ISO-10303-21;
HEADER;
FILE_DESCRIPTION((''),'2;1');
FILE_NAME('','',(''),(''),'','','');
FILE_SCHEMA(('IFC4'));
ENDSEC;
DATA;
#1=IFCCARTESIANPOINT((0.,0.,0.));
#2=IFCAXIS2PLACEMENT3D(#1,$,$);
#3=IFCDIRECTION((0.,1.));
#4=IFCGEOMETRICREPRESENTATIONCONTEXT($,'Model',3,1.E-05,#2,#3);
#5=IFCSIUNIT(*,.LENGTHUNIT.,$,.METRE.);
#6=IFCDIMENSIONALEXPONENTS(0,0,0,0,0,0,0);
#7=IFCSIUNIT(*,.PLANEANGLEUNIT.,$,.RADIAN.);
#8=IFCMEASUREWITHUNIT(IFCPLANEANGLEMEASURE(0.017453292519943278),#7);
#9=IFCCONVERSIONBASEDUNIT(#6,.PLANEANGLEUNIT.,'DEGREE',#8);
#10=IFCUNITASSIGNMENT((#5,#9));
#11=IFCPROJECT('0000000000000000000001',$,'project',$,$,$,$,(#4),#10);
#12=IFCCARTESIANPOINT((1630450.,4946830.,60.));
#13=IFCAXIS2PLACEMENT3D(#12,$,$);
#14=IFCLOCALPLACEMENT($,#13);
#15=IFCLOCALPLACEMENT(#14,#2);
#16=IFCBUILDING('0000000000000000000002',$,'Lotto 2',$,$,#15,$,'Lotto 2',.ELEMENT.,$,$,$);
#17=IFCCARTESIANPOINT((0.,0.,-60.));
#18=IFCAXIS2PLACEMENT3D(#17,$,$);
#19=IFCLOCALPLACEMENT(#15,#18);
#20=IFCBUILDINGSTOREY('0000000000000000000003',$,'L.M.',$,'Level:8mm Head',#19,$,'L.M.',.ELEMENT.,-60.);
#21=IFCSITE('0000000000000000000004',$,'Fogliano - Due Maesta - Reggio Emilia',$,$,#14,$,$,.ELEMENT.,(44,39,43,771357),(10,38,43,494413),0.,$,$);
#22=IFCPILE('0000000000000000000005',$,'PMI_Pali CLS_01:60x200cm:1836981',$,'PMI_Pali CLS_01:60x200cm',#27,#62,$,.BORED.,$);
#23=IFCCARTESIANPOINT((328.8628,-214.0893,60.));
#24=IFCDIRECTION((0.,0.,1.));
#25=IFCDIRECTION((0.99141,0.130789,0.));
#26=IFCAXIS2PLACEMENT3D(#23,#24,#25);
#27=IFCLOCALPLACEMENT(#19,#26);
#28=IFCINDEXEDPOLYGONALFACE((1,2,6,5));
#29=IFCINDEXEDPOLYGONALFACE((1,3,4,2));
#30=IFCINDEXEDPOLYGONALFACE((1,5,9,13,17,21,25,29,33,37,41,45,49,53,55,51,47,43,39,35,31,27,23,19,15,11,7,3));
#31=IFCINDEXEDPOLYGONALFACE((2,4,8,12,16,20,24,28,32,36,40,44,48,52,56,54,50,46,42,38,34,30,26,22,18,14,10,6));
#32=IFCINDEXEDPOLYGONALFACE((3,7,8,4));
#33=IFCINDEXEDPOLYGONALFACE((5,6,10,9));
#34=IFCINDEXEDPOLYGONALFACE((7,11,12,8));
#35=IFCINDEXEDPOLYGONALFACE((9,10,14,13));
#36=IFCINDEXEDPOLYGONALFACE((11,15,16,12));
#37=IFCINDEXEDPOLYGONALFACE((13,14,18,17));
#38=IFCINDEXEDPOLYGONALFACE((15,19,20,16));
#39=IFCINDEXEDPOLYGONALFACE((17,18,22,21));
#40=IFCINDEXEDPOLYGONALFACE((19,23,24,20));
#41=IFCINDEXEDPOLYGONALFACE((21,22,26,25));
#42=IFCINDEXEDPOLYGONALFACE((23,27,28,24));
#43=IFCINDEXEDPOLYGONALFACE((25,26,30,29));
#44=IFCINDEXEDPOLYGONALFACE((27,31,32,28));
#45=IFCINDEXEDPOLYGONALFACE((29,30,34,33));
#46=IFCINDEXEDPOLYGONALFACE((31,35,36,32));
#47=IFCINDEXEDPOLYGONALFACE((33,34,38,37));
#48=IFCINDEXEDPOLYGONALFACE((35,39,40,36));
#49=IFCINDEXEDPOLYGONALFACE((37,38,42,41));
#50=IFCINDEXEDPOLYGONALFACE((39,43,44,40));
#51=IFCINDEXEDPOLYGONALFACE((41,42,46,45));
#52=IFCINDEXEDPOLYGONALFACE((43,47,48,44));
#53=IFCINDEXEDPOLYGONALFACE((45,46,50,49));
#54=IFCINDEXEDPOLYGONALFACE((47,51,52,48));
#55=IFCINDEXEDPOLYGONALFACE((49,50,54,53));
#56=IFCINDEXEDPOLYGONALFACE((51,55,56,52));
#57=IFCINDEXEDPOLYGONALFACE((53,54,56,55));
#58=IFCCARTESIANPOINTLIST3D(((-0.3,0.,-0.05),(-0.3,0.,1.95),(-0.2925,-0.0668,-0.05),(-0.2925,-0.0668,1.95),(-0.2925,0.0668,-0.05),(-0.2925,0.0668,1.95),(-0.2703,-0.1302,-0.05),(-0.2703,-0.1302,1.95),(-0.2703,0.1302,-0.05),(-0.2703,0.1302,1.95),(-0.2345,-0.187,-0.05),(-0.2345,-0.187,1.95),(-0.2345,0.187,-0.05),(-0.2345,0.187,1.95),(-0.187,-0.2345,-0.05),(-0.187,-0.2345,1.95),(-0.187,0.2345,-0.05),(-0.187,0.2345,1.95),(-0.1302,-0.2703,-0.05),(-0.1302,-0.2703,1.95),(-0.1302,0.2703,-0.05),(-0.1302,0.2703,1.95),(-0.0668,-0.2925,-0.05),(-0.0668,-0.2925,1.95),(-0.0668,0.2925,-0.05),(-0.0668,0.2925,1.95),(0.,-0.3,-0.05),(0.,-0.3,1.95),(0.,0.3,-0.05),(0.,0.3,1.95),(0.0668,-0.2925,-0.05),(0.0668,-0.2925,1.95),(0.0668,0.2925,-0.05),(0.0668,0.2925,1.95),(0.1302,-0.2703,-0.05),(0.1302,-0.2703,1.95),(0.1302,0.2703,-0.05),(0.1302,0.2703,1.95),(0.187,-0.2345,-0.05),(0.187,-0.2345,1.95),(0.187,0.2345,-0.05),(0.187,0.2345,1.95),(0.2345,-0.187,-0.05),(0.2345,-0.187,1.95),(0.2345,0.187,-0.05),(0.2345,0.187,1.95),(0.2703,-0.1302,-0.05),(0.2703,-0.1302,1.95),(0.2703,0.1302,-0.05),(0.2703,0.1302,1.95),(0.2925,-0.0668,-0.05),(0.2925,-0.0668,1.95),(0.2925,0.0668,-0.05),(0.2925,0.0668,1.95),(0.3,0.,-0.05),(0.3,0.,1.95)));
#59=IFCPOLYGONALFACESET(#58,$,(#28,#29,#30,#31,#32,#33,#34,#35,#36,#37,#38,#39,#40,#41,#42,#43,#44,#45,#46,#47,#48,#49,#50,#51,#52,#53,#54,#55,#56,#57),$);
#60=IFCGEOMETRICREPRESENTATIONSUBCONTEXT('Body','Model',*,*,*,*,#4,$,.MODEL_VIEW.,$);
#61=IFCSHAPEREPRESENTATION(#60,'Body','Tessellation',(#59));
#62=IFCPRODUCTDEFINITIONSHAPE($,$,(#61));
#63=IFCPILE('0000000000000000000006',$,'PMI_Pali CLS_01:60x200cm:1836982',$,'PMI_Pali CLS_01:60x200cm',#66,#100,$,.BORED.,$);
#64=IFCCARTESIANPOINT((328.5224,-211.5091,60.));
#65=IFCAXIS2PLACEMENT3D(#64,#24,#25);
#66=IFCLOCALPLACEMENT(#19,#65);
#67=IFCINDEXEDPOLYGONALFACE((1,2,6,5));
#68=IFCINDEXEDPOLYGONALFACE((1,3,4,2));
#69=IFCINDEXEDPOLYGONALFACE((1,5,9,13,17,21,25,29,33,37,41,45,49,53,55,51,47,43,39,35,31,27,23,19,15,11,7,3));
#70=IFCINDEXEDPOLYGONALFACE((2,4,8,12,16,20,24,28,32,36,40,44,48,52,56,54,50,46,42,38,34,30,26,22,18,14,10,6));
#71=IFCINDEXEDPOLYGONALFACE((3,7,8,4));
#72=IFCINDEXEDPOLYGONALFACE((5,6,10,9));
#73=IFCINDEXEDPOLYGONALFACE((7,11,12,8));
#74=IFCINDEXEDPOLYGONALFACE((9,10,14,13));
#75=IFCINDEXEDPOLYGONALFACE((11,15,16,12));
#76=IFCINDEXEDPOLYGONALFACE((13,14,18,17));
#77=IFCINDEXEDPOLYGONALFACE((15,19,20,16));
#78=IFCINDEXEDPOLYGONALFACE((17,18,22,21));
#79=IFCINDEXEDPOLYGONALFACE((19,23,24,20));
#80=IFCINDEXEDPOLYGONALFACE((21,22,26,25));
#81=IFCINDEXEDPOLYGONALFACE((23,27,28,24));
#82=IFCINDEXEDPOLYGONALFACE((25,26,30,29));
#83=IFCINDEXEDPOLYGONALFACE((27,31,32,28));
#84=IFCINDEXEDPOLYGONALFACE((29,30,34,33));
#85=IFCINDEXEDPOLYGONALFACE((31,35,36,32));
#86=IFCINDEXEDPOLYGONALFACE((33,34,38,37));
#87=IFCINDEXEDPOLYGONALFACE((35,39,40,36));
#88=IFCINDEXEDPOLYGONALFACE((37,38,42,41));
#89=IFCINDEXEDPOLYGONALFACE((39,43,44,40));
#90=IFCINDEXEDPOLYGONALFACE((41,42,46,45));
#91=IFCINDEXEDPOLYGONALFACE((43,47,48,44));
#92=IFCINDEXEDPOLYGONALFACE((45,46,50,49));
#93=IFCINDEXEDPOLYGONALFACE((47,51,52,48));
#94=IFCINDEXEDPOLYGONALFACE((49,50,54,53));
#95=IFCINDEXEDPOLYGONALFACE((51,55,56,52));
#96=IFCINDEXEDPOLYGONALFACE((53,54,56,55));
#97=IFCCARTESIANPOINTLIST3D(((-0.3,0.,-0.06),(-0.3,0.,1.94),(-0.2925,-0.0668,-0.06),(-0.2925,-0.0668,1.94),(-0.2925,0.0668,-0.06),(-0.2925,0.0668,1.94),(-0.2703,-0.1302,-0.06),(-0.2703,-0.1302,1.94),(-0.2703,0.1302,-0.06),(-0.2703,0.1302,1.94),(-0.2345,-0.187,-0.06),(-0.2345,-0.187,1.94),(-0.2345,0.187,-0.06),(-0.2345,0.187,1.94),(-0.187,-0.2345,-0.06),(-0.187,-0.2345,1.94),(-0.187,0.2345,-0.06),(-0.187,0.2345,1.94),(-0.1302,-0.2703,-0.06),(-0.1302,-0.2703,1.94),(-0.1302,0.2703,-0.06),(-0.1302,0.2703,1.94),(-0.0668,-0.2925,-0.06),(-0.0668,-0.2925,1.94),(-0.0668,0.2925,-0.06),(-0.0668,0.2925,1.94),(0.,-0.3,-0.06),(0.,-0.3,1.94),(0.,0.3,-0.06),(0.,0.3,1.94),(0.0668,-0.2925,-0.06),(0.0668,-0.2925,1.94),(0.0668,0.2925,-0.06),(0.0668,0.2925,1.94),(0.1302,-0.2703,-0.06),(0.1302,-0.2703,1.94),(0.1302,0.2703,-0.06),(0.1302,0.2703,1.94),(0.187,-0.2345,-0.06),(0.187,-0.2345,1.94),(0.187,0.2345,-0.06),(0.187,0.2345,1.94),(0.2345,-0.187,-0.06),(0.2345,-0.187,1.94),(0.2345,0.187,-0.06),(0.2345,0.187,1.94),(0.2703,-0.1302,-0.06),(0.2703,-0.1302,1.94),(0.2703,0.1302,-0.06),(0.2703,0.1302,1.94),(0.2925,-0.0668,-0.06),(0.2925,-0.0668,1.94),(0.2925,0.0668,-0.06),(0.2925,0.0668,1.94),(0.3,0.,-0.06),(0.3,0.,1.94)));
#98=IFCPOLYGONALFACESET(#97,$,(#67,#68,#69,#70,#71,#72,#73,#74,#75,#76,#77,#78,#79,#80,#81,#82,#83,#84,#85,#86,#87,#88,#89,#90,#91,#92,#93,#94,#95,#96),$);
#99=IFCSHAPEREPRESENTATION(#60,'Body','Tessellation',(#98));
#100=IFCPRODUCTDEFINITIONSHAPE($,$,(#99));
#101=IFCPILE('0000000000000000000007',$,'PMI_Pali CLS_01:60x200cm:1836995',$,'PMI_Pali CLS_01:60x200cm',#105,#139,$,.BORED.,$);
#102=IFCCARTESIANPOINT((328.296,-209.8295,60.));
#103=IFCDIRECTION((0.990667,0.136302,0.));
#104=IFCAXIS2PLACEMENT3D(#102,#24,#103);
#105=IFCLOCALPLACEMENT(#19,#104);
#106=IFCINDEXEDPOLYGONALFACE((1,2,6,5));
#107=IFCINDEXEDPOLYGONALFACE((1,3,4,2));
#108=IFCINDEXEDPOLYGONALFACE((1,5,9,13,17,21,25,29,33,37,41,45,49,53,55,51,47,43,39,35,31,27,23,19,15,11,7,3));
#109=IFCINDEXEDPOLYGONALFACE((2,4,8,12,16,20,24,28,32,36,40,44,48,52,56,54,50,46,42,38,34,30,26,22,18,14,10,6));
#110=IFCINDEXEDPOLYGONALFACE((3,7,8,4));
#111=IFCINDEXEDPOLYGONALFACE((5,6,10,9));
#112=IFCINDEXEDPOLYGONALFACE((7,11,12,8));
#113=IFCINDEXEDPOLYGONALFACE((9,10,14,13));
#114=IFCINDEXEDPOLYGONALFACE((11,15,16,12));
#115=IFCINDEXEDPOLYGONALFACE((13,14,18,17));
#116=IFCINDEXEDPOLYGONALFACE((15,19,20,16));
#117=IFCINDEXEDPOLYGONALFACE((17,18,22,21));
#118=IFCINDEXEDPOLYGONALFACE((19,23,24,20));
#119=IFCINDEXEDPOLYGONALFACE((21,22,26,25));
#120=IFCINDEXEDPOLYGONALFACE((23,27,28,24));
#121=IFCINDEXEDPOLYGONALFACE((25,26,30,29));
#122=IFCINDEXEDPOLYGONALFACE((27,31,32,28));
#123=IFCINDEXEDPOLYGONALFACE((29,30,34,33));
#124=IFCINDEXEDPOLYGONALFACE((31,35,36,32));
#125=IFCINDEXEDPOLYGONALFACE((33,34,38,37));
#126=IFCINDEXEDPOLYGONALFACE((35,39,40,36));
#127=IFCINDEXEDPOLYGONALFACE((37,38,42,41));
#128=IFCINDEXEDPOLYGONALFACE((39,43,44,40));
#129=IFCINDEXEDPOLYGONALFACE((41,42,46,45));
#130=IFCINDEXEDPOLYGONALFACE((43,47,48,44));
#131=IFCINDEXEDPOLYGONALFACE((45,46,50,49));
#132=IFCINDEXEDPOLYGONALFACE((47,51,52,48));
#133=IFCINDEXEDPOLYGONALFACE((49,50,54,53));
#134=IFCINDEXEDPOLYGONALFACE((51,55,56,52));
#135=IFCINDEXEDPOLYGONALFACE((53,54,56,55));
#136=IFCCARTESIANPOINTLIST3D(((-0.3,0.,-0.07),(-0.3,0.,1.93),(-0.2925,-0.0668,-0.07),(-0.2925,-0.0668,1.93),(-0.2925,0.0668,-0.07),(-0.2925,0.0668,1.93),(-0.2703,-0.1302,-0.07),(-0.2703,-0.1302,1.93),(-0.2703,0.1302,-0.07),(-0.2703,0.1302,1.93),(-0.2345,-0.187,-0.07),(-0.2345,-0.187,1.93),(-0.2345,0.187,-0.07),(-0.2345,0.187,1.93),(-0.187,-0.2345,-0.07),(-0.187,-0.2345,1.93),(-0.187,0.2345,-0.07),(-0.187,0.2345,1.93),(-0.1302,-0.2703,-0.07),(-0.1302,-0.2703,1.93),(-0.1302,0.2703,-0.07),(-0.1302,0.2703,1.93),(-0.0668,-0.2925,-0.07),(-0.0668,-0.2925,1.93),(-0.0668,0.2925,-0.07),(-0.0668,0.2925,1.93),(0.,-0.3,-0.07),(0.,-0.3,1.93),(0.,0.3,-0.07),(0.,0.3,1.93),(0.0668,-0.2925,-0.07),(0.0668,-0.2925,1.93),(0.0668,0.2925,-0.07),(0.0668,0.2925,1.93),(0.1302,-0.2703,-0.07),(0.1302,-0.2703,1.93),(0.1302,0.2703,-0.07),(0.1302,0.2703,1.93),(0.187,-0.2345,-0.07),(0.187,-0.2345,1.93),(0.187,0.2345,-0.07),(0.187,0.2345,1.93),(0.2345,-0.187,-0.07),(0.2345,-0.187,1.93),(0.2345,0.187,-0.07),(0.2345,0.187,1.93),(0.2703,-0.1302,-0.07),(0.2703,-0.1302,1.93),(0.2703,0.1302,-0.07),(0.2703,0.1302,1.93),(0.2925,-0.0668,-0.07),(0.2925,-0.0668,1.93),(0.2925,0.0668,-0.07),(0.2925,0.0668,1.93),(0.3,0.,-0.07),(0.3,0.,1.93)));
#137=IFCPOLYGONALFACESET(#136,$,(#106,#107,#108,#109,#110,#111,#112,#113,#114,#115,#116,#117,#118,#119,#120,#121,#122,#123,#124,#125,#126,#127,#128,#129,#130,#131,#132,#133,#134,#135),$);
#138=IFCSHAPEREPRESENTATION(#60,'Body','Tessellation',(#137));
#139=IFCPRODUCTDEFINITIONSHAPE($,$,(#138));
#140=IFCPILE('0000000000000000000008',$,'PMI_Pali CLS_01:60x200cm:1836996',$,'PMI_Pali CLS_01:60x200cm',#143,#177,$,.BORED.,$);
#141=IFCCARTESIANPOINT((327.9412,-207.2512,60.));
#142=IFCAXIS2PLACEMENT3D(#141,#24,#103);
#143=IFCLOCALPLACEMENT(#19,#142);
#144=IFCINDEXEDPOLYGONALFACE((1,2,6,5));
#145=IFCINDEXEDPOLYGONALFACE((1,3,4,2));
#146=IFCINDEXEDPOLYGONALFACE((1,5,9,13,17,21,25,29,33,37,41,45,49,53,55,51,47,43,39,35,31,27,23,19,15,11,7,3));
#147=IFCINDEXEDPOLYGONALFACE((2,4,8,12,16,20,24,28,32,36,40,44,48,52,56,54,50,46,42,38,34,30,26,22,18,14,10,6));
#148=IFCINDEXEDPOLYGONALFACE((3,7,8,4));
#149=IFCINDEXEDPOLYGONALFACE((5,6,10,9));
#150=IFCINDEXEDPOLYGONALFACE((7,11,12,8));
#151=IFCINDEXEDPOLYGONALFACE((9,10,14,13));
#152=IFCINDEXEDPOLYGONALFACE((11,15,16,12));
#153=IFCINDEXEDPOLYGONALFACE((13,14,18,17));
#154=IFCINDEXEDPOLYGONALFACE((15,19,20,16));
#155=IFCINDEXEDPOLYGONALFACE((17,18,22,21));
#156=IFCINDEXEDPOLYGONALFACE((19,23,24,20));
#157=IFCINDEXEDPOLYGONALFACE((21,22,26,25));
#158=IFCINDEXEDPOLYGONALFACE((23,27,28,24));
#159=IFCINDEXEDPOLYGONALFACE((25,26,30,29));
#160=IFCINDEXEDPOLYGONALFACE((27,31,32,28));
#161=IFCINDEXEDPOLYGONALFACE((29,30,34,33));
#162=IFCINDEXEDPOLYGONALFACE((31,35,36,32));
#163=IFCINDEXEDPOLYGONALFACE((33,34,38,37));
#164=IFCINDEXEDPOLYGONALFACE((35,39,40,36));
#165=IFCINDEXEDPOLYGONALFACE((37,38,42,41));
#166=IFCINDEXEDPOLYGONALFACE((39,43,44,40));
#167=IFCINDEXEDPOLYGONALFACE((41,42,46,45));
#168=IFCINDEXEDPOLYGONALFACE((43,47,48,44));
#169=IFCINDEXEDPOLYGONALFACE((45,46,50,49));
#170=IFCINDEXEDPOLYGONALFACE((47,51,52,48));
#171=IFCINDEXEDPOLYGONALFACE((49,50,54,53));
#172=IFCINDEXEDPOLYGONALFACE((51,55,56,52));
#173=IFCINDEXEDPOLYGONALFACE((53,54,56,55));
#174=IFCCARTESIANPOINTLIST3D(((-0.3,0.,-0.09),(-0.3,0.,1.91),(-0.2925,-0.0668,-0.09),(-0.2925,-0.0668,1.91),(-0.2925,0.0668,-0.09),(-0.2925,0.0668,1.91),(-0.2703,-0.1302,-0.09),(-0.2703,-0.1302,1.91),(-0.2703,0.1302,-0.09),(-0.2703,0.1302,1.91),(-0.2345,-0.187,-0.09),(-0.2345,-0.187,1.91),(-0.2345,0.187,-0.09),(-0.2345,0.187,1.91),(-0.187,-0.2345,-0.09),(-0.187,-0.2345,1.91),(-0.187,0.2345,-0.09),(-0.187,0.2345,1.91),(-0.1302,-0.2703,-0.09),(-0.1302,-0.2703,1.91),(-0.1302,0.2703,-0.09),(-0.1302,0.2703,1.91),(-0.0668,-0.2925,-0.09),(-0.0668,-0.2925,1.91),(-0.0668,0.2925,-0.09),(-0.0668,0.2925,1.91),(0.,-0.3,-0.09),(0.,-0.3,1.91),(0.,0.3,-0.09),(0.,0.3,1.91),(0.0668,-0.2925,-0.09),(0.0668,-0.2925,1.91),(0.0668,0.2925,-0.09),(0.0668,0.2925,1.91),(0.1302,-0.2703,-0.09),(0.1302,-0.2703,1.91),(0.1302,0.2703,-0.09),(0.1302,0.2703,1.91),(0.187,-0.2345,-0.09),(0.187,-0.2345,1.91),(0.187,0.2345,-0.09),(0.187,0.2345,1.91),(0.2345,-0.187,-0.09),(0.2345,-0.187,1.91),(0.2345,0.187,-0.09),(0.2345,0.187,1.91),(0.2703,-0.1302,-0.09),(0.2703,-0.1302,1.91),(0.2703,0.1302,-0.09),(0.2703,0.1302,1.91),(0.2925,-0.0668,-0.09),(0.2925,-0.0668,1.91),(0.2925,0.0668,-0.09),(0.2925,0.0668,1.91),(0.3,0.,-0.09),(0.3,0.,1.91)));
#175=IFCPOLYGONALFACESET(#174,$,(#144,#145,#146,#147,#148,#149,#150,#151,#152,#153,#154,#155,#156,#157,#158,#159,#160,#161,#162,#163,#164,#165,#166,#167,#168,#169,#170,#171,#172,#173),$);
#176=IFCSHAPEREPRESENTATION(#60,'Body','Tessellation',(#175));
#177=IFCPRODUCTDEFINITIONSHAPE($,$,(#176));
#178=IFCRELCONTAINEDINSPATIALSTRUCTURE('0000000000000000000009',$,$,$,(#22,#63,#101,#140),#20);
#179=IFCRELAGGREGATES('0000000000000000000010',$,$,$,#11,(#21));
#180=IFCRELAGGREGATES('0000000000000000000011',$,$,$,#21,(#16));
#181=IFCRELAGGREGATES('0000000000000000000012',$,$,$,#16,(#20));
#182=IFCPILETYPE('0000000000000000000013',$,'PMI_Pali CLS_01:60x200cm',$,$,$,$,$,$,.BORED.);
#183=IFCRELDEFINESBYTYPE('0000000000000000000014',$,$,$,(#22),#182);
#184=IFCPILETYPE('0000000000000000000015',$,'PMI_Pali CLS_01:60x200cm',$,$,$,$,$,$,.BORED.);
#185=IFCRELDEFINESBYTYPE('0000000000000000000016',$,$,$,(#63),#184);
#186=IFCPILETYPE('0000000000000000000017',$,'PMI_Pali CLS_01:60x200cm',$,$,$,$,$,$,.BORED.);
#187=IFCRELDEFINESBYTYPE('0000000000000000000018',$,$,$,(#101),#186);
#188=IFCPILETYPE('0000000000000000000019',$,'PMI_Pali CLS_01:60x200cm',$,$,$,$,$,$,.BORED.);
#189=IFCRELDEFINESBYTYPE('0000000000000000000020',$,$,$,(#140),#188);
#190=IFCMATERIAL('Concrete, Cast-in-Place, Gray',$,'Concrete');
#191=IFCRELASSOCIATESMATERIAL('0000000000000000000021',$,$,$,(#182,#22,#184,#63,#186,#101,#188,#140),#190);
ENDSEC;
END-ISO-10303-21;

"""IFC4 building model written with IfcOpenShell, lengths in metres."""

from ifc_helpers import new_model, entity, si_unit, converted_unit, direction, frame, origin, place, context, subcontext, project, spatial, arc, indexed_curve, outline, extrude, source, transform, mapped, material, type_object, type_shapes, element, save


model = new_model("IFC4")

# Units and contexts
model_context = context("Model", 3, precision=1e-05, world=origin(), true_north=direction((0.0, 1.0)))
body_context = subcontext(model_context, "Body", "Model", "MODEL_VIEW")
ifc_project = project(units=[si_unit("LENGTHUNIT", "METRE"), converted_unit("PLANEANGLEUNIT", "DEGREE", entity("IfcPlaneAngleMeasure", 0.017453292519943278), si_unit("PLANEANGLEUNIT", "RADIAN"), dimensions=[0, 0, 0, 0, 0, 0, 0])], contexts=[model_context])

# Site, building, storey
site_placement = place(None, frame((1630450.0, 4946830.0, 60.0)))
site = spatial("IfcSite", under=ifc_project, at=site_placement, Name="Fogliano - Due Maesta - Reggio Emilia", CompositionType="ELEMENT", RefLatitude=(44, 39, 43, 771357), RefLongitude=(10, 38, 43, 494413), RefElevation=0.0)
building_placement = place(site_placement, origin())
building = spatial("IfcBuilding", under=site, at=building_placement, Name="Lotto 2", LongName="Lotto 2", CompositionType="ELEMENT")
storey_placement = place(building_placement, frame((0.0, 0.0, -60.0)))
storey = spatial("IfcBuildingStorey", under=building, at=storey_placement, Name="L.M.", ObjectType="Level:8mm Head", LongName="L.M.", CompositionType="ELEMENT", Elevation=-60.0)

# Piles
ifc_material_1 = material(Name="Concrete, Cast-in-Place, Gray", Category="Concrete")
pile_type_1 = type_object("IfcPileType", Name="PMI_Pali CLS_01:60x200cm", PredefinedType="BORED", material=ifc_material_1)
shared_shape_1 = source(origin(), body_context, "Body", "SweptSolid", [
    extrude(outline(indexed_curve([(-0.3, 0.0), (0.0, -0.3), (0.3, 0.0), (0.0, 0.3)], segments=[arc(1, 2, 3), arc(3, 4, 1)], self_intersect=False)), frame((0.0, 0.0, -0.05)), (0.0, 0.0, 1.0), 2.0),
])
type_shapes(pile_type_1, [shared_shape_1])
pile_1_placement = place(storey_placement, frame((328.8628, -214.0893, 60.0), z_axis=(0.0, 0.0, 1.0), x_axis=(0.99141, 0.130789, 0.0)))
element("IfcPile", 1, at=pile_1_placement, inside=storey, type_object=pile_type_1, material=ifc_material_1, Name="PMI_Pali CLS_01:60x200cm:1836981", ObjectType="PMI_Pali CLS_01:60x200cm", PredefinedType="BORED", context=body_context, shape_type="MappedRepresentation", body=[
    mapped(shared_shape_1, transform((0.0, 0.0, 0.0), scale=1.0)),
])
pile_type_2 = type_object("IfcPileType", Name="PMI_Pali CLS_01:60x200cm", PredefinedType="BORED", material=ifc_material_1)
shared_shape_2 = source(origin(), body_context, "Body", "SweptSolid", [
    extrude(outline(indexed_curve([(-0.3, 0.0), (0.0, -0.3), (0.3, 0.0), (0.0, 0.3)], segments=[arc(1, 2, 3), arc(3, 4, 1)], self_intersect=False)), frame((0.0, 0.0, -0.06)), (0.0, 0.0, 1.0), 2.0),
])
type_shapes(pile_type_2, [shared_shape_2])
pile_2_placement = place(storey_placement, frame((328.5224, -211.5091, 60.0), z_axis=(0.0, 0.0, 1.0), x_axis=(0.99141, 0.130789, 0.0)))
element("IfcPile", 2, at=pile_2_placement, inside=storey, type_object=pile_type_2, material=ifc_material_1, Name="PMI_Pali CLS_01:60x200cm:1836982", ObjectType="PMI_Pali CLS_01:60x200cm", PredefinedType="BORED", context=body_context, shape_type="MappedRepresentation", body=[
    mapped(shared_shape_2, transform((0.0, 0.0, 0.0), scale=1.0)),
])
pile_type_3 = type_object("IfcPileType", Name="PMI_Pali CLS_01:60x200cm", PredefinedType="BORED", material=ifc_material_1)
shared_shape_3 = source(origin(), body_context, "Body", "SweptSolid", [
    extrude(outline(indexed_curve([(-0.3, 0.0), (0.0, -0.3), (0.3, 0.0), (0.0, 0.3)], segments=[arc(1, 2, 3), arc(3, 4, 1)], self_intersect=False)), frame((0.0, 0.0, -0.07)), (0.0, 0.0, 1.0), 2.0),
])
type_shapes(pile_type_3, [shared_shape_3])
pile_3_placement = place(storey_placement, frame((328.296, -209.8295, 60.0), z_axis=(0.0, 0.0, 1.0), x_axis=(0.990667, 0.136302, 0.0)))
element("IfcPile", 3, at=pile_3_placement, inside=storey, type_object=pile_type_3, material=ifc_material_1, Name="PMI_Pali CLS_01:60x200cm:1836995", ObjectType="PMI_Pali CLS_01:60x200cm", PredefinedType="BORED", context=body_context, shape_type="MappedRepresentation", body=[
    mapped(shared_shape_3, transform((0.0, 0.0, 0.0), scale=1.0)),
])
pile_type_4 = type_object("IfcPileType", Name="PMI_Pali CLS_01:60x200cm", PredefinedType="BORED", material=ifc_material_1)
shared_shape_4 = source(origin(), body_context, "Body", "SweptSolid", [
    extrude(outline(indexed_curve([(-0.3, 0.0), (0.0, -0.3), (0.3, 0.0), (0.0, 0.3)], segments=[arc(1, 2, 3), arc(3, 4, 1)], self_intersect=False)), frame((0.0, 0.0, -0.09)), (0.0, 0.0, 1.0), 2.0),
])
type_shapes(pile_type_4, [shared_shape_4])
pile_4_placement = place(storey_placement, frame((327.9412, -207.2512, 60.0), z_axis=(0.0, 0.0, 1.0), x_axis=(0.990667, 0.136302, 0.0)))
element("IfcPile", 4, at=pile_4_placement, inside=storey, type_object=pile_type_4, material=ifc_material_1, Name="PMI_Pali CLS_01:60x200cm:1836996", ObjectType="PMI_Pali CLS_01:60x200cm", PredefinedType="BORED", context=body_context, shape_type="MappedRepresentation", body=[
    mapped(shared_shape_4, transform((0.0, 0.0, 0.0), scale=1.0)),
])

save(model, "model.ifc")
